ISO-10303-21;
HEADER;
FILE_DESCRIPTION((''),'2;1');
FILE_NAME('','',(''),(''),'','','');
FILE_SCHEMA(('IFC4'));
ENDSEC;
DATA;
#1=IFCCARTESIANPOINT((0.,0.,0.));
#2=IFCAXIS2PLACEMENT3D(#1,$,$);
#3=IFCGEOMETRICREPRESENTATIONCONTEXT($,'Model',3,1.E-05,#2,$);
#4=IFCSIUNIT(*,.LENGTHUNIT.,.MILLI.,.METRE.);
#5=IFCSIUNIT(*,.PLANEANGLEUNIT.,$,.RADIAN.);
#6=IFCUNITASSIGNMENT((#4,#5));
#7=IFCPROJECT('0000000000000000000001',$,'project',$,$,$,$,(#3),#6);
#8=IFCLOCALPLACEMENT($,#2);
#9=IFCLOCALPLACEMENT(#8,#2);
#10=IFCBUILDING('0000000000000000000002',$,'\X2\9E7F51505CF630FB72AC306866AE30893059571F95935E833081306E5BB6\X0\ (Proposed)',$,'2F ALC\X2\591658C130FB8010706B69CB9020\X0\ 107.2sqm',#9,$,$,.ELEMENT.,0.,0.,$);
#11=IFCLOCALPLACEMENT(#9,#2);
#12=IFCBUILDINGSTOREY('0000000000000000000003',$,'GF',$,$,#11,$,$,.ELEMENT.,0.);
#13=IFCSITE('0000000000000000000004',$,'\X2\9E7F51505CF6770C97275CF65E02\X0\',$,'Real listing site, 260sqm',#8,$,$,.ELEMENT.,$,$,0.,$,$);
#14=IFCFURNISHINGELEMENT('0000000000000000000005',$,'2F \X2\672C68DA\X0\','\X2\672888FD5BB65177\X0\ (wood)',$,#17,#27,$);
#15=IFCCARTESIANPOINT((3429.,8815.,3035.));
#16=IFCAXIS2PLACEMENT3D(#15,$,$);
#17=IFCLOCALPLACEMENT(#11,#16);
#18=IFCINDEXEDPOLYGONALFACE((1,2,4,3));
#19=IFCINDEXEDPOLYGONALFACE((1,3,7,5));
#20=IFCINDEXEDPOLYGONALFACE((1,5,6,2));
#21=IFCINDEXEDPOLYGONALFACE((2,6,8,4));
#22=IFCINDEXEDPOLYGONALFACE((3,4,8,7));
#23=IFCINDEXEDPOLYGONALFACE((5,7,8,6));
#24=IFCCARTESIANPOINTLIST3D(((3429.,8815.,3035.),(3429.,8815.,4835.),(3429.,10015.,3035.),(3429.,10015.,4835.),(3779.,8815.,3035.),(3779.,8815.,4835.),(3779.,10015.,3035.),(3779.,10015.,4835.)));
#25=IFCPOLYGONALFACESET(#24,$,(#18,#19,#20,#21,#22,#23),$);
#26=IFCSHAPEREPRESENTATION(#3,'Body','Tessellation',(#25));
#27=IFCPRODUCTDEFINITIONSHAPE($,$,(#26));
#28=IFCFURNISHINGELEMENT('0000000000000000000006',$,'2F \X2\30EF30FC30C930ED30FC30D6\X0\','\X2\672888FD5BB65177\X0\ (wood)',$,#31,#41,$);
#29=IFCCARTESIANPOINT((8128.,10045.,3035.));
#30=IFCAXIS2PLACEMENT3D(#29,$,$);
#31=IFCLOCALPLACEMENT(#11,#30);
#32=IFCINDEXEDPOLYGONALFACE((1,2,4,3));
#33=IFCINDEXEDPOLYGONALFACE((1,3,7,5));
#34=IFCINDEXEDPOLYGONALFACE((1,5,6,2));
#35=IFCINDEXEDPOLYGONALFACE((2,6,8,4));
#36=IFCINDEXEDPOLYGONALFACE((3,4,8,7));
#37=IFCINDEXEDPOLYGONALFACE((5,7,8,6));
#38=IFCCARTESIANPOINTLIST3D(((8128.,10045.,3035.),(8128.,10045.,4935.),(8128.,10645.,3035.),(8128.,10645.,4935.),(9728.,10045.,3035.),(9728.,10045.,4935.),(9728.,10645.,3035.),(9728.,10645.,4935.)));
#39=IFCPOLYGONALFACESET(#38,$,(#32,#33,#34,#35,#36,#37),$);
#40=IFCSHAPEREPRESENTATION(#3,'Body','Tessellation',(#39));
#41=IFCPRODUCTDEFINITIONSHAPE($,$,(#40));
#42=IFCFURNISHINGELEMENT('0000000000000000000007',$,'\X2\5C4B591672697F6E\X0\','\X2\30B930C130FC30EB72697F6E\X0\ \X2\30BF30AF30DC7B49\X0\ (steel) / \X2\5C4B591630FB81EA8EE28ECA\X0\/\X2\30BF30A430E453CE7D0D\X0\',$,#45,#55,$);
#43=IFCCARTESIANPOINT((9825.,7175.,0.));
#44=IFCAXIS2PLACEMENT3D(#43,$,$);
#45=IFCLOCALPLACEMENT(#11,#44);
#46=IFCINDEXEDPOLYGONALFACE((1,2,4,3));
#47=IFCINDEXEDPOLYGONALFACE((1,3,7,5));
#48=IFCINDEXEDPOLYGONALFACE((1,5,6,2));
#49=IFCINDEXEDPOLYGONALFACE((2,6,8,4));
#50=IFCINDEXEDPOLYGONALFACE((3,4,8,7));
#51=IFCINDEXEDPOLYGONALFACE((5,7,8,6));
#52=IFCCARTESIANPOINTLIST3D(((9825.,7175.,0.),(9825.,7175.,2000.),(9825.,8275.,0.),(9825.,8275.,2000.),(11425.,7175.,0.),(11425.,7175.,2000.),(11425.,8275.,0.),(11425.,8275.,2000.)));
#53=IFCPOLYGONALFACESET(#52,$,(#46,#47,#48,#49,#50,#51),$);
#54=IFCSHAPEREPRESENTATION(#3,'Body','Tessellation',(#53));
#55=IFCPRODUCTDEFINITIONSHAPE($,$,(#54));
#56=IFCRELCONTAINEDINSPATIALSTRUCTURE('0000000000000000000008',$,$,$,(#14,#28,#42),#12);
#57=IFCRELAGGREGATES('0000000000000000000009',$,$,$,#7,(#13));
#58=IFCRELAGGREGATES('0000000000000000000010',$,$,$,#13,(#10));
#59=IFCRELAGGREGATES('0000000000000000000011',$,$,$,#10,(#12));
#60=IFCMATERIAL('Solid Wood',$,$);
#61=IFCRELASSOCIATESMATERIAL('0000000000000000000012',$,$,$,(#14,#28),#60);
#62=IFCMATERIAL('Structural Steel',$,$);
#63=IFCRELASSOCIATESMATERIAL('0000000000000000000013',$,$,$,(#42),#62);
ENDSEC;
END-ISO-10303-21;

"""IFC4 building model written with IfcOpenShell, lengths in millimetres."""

from ifc_helpers import new_model, si_unit, frame, frame_2d, origin, place, context, project, spatial, rectangle, extrude, material, element, save


model = new_model("IFC4")

# Units and contexts
model_context = context("Model", 3, precision=1e-05, world=origin())
ifc_project = project(units=[si_unit("LENGTHUNIT", "METRE", prefix="MILLI"), si_unit("PLANEANGLEUNIT", "RADIAN")], contexts=[model_context])

# Site, building, storey
site_placement = place(None, origin())
site = spatial("IfcSite", under=ifc_project, at=site_placement, Name="鹿児島県霧島市", ObjectType="Real listing site, 260sqm", CompositionType="ELEMENT", RefElevation=0.0)
building_placement = place(site_placement, origin())
building = spatial("IfcBuilding", under=site, at=building_placement, Name="鹿児島・犬と暮らす土間広めの家 (Proposed)", ObjectType="2F ALC外壁・耐火構造 107.2sqm", CompositionType="ELEMENT", ElevationOfRefHeight=0.0, ElevationOfTerrain=0.0)
storey_placement = place(building_placement, origin())
storey = spatial("IfcBuildingStorey", under=building, at=storey_placement, Name="GF", CompositionType="ELEMENT", Elevation=0.0)

# Shared definitions
ifc_material_1 = material(Name="Solid Wood")

# Shared definitions
ifc_material_2 = material(Name="Structural Steel")

# Furnishing elements
furnishing_1_placement = place(storey_placement, frame((3429.0, 8815.0, 3035.0)))
element("IfcFurnishingElement", 1, at=furnishing_1_placement, inside=storey, material=ifc_material_1, Name="2F 本棚", Description="木製家具 (wood)", context=model_context, shape_type="SweptSolid", body=[
    extrude(rectangle(XDim=350.0, YDim=1200.0, at=frame_2d((175.0, 600.0))), frame((3429.0, 8815.0, 3035.0)), (0.0, 0.0, 1.0), 1800.0),
])
furnishing_2_placement = place(storey_placement, frame((8128.0, 10045.0, 3035.0)))
element("IfcFurnishingElement", 2, at=furnishing_2_placement, inside=storey, material=ifc_material_1, Name="2F ワードローブ", Description="木製家具 (wood)", context=model_context, shape_type="SweptSolid", body=[
    extrude(rectangle(XDim=1600.0, YDim=600.0, at=frame_2d((800.0, 300.0))), frame((8128.0, 10045.0, 3035.0)), (0.0, 0.0, 1.0), 1900.0),
])
furnishing_3_placement = place(storey_placement, frame((9825.0, 7175.0, 0.0)))
element("IfcFurnishingElement", 3, at=furnishing_3_placement, inside=storey, material=ifc_material_2, Name="屋外物置", Description="スチール物置 タクボ等 (steel) / 屋外・自転車/タイヤ収納", context=model_context, shape_type="SweptSolid", body=[
    extrude(rectangle(XDim=1600.0, YDim=1100.0, at=frame_2d((800.0, 550.0))), frame((9825.0, 7175.0, 0.0)), (0.0, 0.0, 1.0), 2000.0),
])

save(model, "model.ifc")
